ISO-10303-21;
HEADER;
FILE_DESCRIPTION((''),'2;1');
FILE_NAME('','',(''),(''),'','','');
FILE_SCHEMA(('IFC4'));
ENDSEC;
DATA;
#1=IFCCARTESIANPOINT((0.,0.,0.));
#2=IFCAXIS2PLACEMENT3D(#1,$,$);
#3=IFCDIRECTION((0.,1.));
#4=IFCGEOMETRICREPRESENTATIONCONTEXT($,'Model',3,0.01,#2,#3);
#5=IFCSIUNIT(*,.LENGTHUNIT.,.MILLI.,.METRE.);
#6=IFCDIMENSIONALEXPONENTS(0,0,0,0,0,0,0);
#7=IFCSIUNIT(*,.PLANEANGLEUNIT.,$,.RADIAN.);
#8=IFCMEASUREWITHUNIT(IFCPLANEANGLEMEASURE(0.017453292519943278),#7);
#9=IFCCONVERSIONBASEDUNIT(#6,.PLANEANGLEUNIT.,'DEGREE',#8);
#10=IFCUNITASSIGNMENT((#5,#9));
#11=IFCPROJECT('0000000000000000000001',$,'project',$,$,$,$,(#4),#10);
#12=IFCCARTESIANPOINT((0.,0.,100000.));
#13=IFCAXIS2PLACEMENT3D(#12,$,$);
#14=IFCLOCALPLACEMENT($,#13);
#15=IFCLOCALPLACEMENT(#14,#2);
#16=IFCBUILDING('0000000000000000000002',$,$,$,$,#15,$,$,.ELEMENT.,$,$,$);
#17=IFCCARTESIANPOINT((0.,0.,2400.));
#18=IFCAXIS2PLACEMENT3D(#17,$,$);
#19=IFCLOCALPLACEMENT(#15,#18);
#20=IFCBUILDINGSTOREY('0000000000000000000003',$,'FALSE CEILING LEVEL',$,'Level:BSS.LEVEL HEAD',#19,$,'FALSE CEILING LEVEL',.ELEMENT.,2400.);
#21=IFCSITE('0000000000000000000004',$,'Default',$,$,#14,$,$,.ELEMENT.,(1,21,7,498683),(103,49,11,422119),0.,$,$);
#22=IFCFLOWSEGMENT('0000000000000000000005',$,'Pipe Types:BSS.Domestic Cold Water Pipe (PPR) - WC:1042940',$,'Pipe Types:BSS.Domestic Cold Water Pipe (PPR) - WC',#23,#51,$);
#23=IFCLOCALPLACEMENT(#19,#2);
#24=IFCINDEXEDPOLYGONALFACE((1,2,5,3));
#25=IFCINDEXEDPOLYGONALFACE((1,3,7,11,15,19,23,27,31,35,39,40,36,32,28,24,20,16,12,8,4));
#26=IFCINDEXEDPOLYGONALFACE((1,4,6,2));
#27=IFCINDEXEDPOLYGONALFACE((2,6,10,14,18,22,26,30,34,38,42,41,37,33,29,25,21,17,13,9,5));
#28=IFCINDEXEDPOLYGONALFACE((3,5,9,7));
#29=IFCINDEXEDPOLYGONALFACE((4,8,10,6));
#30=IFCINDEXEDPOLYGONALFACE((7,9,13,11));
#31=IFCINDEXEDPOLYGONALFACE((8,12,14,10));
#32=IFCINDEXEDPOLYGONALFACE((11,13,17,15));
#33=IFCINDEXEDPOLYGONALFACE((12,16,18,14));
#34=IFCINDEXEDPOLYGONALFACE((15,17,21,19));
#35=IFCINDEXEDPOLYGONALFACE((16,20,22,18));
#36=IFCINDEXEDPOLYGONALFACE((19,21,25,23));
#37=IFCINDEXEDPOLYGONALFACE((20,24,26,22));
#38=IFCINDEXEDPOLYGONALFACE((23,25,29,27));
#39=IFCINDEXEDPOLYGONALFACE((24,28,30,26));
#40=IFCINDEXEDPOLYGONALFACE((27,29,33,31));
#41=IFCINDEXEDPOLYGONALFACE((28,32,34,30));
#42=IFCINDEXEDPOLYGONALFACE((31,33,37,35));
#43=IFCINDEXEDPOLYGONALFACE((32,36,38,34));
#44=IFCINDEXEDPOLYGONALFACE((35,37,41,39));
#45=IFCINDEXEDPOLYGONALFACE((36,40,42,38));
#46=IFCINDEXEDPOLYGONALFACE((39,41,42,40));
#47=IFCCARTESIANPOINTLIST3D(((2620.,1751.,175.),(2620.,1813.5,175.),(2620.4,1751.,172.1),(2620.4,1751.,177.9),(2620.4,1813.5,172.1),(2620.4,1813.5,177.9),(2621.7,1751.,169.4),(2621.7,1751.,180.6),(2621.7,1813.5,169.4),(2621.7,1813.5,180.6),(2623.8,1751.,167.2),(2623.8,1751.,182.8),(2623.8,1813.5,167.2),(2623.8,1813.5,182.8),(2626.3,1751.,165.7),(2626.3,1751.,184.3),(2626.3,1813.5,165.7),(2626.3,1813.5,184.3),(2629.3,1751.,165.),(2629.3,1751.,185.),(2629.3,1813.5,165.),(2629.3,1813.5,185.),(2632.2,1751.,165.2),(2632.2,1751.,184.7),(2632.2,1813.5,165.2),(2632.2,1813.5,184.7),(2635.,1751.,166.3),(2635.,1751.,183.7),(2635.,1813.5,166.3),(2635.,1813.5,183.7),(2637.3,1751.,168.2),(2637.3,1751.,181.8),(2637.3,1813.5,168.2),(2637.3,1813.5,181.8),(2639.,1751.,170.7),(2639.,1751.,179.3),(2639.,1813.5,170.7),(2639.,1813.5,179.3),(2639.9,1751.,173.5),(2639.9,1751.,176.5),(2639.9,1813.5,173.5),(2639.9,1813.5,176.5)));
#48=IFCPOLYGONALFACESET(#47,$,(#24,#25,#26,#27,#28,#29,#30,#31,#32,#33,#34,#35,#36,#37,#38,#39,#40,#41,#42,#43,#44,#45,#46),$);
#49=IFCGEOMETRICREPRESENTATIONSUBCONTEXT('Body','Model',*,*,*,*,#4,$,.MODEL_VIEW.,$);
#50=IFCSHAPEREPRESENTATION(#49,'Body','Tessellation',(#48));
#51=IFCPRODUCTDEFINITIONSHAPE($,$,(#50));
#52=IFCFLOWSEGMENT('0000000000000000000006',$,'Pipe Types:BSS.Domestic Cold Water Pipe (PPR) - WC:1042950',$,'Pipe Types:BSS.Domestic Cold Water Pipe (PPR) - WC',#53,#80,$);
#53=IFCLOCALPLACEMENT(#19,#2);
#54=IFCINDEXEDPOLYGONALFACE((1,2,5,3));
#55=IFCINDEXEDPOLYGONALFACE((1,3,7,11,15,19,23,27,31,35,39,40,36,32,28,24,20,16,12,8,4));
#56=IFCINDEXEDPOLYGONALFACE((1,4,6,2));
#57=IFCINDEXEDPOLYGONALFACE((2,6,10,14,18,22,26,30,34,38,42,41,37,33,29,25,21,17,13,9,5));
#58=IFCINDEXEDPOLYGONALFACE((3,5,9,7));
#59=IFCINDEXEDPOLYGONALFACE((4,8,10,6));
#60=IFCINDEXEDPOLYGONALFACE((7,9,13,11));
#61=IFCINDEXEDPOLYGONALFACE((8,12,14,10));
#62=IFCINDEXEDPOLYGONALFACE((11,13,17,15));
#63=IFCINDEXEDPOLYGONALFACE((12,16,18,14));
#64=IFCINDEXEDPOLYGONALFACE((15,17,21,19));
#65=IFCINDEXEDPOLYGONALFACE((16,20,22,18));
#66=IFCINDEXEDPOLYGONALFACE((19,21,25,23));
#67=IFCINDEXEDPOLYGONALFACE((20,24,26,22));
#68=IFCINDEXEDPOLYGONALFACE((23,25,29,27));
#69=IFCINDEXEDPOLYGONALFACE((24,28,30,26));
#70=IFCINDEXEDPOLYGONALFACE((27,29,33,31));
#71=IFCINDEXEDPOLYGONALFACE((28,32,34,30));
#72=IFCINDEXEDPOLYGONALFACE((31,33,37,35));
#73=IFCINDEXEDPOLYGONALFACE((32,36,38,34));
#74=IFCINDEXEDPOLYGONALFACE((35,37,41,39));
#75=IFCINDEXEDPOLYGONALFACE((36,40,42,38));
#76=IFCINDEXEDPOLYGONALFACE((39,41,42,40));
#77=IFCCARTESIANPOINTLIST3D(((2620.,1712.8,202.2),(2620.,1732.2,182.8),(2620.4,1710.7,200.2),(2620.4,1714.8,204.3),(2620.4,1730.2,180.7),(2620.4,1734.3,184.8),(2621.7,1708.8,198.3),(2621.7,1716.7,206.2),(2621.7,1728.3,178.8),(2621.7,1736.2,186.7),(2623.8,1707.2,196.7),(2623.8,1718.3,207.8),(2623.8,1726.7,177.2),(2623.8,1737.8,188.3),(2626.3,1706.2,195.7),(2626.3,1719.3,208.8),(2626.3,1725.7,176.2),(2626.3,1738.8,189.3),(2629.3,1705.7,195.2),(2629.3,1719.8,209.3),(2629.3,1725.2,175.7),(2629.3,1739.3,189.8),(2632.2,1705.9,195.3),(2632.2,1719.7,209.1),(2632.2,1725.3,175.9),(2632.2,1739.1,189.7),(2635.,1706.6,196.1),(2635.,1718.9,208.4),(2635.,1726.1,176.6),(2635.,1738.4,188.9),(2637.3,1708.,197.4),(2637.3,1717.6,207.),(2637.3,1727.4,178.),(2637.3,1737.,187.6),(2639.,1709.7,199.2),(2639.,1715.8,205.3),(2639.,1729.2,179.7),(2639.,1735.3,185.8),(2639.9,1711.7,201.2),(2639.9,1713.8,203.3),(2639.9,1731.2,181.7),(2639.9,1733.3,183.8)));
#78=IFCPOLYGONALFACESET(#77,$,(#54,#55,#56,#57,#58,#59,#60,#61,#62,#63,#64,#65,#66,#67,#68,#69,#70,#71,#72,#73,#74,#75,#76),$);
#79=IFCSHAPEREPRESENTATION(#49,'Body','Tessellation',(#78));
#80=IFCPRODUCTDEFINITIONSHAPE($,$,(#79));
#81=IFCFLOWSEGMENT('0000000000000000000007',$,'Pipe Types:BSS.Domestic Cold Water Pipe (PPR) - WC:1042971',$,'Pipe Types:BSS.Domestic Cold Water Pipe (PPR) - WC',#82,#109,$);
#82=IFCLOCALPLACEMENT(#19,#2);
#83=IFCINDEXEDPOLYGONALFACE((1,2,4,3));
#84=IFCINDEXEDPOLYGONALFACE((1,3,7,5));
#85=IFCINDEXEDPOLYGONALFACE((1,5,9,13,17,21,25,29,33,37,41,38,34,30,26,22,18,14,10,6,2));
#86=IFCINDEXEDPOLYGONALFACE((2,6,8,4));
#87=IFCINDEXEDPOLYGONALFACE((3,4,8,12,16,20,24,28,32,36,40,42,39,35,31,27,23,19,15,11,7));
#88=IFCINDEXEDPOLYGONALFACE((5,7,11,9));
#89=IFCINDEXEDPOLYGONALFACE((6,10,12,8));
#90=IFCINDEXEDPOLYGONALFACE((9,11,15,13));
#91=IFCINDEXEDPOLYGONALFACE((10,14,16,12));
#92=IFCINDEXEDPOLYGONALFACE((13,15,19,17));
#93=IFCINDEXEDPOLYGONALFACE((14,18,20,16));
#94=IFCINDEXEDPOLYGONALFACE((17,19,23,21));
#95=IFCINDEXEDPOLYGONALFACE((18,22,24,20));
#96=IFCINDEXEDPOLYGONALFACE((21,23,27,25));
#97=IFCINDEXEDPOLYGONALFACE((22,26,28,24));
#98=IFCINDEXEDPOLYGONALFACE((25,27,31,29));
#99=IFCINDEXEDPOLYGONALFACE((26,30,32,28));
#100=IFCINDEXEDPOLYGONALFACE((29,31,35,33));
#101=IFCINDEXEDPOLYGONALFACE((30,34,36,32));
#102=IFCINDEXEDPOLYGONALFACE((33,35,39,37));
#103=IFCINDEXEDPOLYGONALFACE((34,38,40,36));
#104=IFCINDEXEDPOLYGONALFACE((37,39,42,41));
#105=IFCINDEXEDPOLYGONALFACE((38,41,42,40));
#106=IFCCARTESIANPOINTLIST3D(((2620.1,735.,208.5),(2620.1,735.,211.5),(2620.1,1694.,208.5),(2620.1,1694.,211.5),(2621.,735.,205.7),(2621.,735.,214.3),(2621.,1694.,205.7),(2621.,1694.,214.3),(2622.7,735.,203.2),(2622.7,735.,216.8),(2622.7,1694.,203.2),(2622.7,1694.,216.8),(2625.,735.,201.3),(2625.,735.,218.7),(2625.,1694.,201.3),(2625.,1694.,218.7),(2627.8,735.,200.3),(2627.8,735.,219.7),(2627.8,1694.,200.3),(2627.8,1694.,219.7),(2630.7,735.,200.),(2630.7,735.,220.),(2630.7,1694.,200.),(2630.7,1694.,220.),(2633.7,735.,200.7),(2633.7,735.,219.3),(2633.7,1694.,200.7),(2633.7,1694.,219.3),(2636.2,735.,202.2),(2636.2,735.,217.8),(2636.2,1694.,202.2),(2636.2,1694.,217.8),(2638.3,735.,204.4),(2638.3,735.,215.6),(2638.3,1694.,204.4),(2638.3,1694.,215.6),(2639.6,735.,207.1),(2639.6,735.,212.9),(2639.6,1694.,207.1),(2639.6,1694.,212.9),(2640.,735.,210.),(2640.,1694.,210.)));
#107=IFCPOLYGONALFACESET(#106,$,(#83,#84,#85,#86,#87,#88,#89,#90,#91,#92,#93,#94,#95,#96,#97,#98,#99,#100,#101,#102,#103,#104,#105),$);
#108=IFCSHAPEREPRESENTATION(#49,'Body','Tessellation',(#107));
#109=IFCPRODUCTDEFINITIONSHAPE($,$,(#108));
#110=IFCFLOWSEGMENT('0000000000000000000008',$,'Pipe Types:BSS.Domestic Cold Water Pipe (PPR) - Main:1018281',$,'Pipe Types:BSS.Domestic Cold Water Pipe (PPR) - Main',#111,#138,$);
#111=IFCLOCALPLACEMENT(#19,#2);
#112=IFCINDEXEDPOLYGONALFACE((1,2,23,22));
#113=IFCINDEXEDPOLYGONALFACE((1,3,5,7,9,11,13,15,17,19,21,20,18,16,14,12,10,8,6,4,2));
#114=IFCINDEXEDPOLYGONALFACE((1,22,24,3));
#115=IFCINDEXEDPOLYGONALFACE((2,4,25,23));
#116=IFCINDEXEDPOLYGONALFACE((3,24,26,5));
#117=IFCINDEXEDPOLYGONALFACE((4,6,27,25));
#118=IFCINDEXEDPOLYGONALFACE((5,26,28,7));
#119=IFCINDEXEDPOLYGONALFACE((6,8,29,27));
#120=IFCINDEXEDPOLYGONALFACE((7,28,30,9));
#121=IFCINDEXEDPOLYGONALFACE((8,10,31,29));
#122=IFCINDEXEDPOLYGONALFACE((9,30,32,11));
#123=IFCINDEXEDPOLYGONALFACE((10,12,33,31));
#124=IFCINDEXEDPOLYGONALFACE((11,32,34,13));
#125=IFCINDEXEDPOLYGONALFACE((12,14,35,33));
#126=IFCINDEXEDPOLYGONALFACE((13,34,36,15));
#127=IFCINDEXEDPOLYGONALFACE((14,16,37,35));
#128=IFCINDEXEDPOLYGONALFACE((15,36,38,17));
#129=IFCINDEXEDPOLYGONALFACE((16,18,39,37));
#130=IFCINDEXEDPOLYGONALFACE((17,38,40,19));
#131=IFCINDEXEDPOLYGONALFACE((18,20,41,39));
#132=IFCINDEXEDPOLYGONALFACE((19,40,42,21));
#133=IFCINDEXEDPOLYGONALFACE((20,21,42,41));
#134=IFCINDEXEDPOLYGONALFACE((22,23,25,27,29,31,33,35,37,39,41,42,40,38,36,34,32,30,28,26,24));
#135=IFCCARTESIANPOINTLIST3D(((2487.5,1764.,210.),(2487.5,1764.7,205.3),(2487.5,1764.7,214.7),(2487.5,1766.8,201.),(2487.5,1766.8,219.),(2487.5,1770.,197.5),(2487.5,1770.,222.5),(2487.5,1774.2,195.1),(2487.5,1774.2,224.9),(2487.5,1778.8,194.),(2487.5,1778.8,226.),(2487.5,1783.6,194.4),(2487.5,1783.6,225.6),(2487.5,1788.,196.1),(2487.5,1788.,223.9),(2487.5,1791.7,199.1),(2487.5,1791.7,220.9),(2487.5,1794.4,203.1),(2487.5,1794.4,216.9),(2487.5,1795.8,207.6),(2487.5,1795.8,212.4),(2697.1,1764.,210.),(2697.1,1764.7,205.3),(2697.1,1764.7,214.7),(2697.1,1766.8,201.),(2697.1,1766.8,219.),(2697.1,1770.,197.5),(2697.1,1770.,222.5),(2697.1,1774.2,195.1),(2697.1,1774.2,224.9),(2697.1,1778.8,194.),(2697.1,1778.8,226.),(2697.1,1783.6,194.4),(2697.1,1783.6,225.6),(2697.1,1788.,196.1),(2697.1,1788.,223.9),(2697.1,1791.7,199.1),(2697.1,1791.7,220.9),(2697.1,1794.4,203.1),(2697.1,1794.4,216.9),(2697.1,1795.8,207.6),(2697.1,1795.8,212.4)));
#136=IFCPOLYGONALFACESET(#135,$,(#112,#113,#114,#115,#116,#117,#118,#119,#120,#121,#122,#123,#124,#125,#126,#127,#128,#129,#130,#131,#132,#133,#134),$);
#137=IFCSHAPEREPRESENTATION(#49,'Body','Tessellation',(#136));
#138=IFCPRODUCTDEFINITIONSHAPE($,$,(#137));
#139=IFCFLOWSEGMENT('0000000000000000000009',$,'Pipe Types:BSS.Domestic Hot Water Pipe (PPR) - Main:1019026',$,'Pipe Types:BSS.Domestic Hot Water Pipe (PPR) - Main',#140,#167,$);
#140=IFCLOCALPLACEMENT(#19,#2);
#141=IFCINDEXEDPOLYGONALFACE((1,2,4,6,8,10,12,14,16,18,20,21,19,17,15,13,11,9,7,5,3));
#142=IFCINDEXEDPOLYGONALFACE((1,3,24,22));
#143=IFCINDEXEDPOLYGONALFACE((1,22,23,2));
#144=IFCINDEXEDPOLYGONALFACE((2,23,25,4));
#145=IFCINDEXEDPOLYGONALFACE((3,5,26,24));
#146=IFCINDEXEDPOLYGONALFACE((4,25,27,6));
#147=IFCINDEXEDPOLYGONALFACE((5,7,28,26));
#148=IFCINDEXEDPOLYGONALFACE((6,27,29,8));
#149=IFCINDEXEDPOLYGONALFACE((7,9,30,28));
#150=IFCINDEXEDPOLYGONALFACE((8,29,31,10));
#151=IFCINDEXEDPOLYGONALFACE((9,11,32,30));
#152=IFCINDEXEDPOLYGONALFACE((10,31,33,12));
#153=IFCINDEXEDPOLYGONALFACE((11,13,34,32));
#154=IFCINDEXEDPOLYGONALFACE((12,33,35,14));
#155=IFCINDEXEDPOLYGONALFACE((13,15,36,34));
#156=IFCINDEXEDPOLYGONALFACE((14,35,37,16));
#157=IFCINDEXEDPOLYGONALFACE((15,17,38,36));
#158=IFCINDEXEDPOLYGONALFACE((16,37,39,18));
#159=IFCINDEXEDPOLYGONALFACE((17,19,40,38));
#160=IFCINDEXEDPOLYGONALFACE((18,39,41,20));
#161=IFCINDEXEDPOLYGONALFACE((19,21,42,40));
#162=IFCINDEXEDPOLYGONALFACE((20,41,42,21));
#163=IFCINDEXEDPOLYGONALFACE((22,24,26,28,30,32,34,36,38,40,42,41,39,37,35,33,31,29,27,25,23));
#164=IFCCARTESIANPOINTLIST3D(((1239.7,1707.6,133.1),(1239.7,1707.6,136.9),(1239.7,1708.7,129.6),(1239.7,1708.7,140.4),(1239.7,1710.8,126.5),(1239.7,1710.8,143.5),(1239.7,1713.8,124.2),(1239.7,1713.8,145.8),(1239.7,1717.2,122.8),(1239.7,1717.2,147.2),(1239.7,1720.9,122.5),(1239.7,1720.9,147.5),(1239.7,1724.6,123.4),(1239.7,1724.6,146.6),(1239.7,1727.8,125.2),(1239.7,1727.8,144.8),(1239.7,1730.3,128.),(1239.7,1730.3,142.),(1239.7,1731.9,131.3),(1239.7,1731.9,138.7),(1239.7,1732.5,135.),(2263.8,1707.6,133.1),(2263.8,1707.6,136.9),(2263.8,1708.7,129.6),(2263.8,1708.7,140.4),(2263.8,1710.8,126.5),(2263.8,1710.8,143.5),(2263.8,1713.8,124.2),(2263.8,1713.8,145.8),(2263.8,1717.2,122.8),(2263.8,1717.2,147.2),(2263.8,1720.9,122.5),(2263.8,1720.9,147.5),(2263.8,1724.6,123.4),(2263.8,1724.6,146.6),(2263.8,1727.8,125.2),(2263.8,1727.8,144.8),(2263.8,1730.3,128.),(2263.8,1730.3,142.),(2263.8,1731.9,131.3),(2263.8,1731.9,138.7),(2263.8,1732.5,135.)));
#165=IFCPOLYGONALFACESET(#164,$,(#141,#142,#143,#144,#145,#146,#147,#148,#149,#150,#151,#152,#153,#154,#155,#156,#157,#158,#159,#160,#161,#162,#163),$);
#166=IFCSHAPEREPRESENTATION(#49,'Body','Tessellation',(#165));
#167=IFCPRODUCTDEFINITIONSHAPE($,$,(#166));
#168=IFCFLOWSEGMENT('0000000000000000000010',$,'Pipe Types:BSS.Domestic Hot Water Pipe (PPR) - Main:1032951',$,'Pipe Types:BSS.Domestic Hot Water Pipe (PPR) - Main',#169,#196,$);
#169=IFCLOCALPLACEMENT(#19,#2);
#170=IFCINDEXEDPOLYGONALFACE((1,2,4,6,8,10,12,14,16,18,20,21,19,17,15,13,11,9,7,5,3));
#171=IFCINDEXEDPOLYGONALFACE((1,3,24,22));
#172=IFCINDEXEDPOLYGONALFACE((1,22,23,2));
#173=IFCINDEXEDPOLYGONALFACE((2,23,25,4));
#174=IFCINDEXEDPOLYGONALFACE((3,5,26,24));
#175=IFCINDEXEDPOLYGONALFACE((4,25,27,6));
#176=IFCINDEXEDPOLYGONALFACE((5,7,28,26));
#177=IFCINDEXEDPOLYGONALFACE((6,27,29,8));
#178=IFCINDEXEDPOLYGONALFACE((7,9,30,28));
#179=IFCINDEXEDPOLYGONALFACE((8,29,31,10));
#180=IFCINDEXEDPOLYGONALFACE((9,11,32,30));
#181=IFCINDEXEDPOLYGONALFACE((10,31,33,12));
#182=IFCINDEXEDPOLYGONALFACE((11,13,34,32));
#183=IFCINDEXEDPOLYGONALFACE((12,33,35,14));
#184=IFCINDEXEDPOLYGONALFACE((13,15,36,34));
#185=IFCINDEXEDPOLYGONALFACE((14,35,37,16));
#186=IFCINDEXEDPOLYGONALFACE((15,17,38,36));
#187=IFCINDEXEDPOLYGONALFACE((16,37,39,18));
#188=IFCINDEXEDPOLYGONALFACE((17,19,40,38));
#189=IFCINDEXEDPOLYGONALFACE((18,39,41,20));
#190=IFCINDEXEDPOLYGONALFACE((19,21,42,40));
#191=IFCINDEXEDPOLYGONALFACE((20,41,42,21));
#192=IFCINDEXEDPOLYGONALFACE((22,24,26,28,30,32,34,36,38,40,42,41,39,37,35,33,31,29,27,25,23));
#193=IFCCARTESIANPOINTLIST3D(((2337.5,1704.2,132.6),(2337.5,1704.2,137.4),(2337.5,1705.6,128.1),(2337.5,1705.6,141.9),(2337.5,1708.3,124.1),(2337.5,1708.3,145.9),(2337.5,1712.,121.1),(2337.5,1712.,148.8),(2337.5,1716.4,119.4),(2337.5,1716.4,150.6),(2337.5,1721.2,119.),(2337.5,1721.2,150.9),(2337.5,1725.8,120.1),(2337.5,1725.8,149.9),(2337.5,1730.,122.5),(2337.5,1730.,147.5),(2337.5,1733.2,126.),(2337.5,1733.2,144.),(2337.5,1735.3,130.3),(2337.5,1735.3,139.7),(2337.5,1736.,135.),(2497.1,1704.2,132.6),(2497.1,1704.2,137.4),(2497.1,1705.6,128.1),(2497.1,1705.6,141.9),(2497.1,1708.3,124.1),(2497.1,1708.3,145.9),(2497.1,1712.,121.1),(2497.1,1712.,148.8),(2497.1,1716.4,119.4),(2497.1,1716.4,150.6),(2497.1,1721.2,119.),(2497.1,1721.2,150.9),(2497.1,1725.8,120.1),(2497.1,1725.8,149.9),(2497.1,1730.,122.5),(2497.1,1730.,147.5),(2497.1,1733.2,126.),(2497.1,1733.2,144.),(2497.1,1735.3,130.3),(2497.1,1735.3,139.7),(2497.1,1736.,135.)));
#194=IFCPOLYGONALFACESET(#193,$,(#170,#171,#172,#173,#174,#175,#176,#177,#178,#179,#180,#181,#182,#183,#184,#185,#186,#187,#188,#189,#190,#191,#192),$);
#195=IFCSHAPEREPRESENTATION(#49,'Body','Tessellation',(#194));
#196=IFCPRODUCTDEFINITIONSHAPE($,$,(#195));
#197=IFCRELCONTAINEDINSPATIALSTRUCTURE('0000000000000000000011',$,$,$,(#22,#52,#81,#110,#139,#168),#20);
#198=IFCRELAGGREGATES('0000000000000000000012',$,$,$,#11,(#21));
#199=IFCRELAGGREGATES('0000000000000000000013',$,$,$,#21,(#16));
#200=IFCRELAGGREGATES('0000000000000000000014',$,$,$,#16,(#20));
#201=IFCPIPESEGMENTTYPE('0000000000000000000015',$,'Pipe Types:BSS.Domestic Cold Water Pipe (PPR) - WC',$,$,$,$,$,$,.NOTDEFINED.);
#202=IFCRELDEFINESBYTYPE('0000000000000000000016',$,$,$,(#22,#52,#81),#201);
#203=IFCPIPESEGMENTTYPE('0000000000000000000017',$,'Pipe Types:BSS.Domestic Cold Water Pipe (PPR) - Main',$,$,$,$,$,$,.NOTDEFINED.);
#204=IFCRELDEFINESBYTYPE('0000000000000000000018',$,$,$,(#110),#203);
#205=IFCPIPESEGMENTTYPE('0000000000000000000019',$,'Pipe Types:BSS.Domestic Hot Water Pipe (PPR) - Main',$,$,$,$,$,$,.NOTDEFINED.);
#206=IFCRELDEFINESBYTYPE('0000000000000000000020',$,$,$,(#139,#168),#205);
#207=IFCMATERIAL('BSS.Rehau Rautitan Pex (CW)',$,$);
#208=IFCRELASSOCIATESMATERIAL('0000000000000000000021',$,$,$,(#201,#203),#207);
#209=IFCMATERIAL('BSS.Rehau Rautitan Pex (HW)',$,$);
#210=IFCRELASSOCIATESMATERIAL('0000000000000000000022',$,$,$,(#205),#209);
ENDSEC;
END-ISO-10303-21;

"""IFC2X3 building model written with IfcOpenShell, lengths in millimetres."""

from ifc_helpers import new_model, entity, si_unit, converted_unit, direction, frame, frame_2d, origin, origin_2d_with_axis, place, context, subcontext, project, spatial, circle, extrude, material, type_object, element, save


model = new_model("IFC2X3")

# Units and contexts
model_context = context("Model", 3, precision=0.01, world=origin(), true_north=direction((0.0, 1.0)))
body_context = subcontext(model_context, "Body", "Model", "MODEL_VIEW")
ifc_project = project(units=[si_unit("LENGTHUNIT", "METRE", prefix="MILLI"), converted_unit("PLANEANGLEUNIT", "DEGREE", entity("IfcPlaneAngleMeasure", 0.017453292519943278), si_unit("PLANEANGLEUNIT", "RADIAN"), dimensions=[0, 0, 0, 0, 0, 0, 0])], contexts=[model_context])

# Site, building, storey
site_placement = place(None, frame((0.0, 0.0, 100000.0)))
site = spatial("IfcSite", under=ifc_project, at=site_placement, Name="Default", CompositionType="ELEMENT", RefLatitude=(1, 21, 7, 498683), RefLongitude=(103, 49, 11, 422119), RefElevation=0.0)
building_placement = place(site_placement, origin())
building = spatial("IfcBuilding", under=site, at=building_placement, CompositionType="ELEMENT")
storey_placement = place(building_placement, frame((0.0, 0.0, 2400.0)))
storey = spatial("IfcBuildingStorey", under=building, at=storey_placement, Name="FALSE CEILING LEVEL", ObjectType="Level:BSS.LEVEL HEAD", LongName="FALSE CEILING LEVEL", CompositionType="ELEMENT", Elevation=2400.0)

# Flow segments
ifc_material_1 = material(Name="BSS.Rehau Rautitan Pex (HW)")
ifc_material_2 = material(Name="BSS.Rehau Rautitan Pex (CW)")
pipe_segment_type_1 = type_object("IfcPipeSegmentType", Name="Pipe Types:BSS.Domestic Cold Water Pipe (PPR) - WC", PredefinedType="NOTDEFINED", material=ifc_material_2)
flow_segment_1_placement = place(storey_placement, origin())
element("IfcFlowSegment", 1, at=flow_segment_1_placement, inside=storey, type_object=pipe_segment_type_1, Name="Pipe Types:BSS.Domestic Cold Water Pipe (PPR) - WC:1042940", ObjectType="Pipe Types:BSS.Domestic Cold Water Pipe (PPR) - WC", context=body_context, shape_type="SweptSolid", body=[
    extrude(circle(Radius=10.0, at=frame_2d((0.0, 0.0), x_axis=(1.0, 0.0))), frame((2630.0, 1751.0, 175.0), z_axis=(0.0, 1.0, 0.0), x_axis=(-1.0, 0.0, 0.0)), (0.0, 0.0, 1.0), 62.5),
])
flow_segment_2_placement = place(storey_placement, origin())
element("IfcFlowSegment", 2, at=flow_segment_2_placement, inside=storey, type_object=pipe_segment_type_1, Name="Pipe Types:BSS.Domestic Cold Water Pipe (PPR) - WC:1042950", ObjectType="Pipe Types:BSS.Domestic Cold Water Pipe (PPR) - WC", context=body_context, shape_type="SweptSolid", body=[
    extrude(circle(Radius=10.0, at=frame_2d((0.0, 0.0), x_axis=(1.0, 0.0))), frame((2630.0, 1712.8, 202.2), z_axis=(0.0, 0.707107, -0.707107), x_axis=(-1.0, 0.0, 0.0)), (0.0, 0.0, 1.0), 27.5),
])
flow_segment_3_placement = place(storey_placement, origin())
element("IfcFlowSegment", 3, at=flow_segment_3_placement, inside=storey, type_object=pipe_segment_type_1, Name="Pipe Types:BSS.Domestic Cold Water Pipe (PPR) - WC:1042971", ObjectType="Pipe Types:BSS.Domestic Cold Water Pipe (PPR) - WC", context=body_context, shape_type="SweptSolid", body=[
    extrude(circle(Radius=10.0, at=origin_2d_with_axis()), frame((2630.0, 735.0, 210.0), z_axis=(0.0, 1.0, 0.0), x_axis=(1.0, 0.0, 0.0)), (0.0, 0.0, 1.0), 959.0),
])
pipe_segment_type_2 = type_object("IfcPipeSegmentType", Name="Pipe Types:BSS.Domestic Cold Water Pipe (PPR) - Main", PredefinedType="NOTDEFINED", material=ifc_material_2)
flow_segment_4_placement = place(storey_placement, origin())
element("IfcFlowSegment", 4, at=flow_segment_4_placement, inside=storey, type_object=pipe_segment_type_2, Name="Pipe Types:BSS.Domestic Cold Water Pipe (PPR) - Main:1018281", ObjectType="Pipe Types:BSS.Domestic Cold Water Pipe (PPR) - Main", context=body_context, shape_type="SweptSolid", body=[
    extrude(circle(Radius=16.0, at=frame_2d((0.0, 0.0), x_axis=(1.0, 0.0))), frame((2487.5, 1780.0, 210.0), z_axis=(1.0, 0.0, 0.0), x_axis=(0.0, -1.0, 0.0)), (0.0, 0.0, 1.0), 209.7),
])
pipe_segment_type_3 = type_object("IfcPipeSegmentType", Name="Pipe Types:BSS.Domestic Hot Water Pipe (PPR) - Main", PredefinedType="NOTDEFINED", material=ifc_material_1)
flow_segment_5_placement = place(storey_placement, origin())
element("IfcFlowSegment", 5, at=flow_segment_5_placement, inside=storey, type_object=pipe_segment_type_3, Name="Pipe Types:BSS.Domestic Hot Water Pipe (PPR) - Main:1019026", ObjectType="Pipe Types:BSS.Domestic Hot Water Pipe (PPR) - Main", context=body_context, shape_type="SweptSolid", body=[
    extrude(circle(Radius=12.5, at=frame_2d((0.0, 0.0), x_axis=(1.0, 0.0))), frame((1239.7, 1720.0, 135.0), z_axis=(1.0, 0.0, 0.0), x_axis=(0.0, 1.0, 0.0)), (0.0, 0.0, 1.0), 1024.1),
])
flow_segment_6_placement = place(storey_placement, origin())
element("IfcFlowSegment", 6, at=flow_segment_6_placement, inside=storey, type_object=pipe_segment_type_3, Name="Pipe Types:BSS.Domestic Hot Water Pipe (PPR) - Main:1032951", ObjectType="Pipe Types:BSS.Domestic Hot Water Pipe (PPR) - Main", context=body_context, shape_type="SweptSolid", body=[
    extrude(circle(Radius=16.0, at=origin_2d_with_axis()), frame((2337.5, 1720.0, 135.0), z_axis=(1.0, 0.0, 0.0), x_axis=(0.0, 1.0, 0.0)), (0.0, 0.0, 1.0), 159.7),
])

save(model, "model.ifc")
